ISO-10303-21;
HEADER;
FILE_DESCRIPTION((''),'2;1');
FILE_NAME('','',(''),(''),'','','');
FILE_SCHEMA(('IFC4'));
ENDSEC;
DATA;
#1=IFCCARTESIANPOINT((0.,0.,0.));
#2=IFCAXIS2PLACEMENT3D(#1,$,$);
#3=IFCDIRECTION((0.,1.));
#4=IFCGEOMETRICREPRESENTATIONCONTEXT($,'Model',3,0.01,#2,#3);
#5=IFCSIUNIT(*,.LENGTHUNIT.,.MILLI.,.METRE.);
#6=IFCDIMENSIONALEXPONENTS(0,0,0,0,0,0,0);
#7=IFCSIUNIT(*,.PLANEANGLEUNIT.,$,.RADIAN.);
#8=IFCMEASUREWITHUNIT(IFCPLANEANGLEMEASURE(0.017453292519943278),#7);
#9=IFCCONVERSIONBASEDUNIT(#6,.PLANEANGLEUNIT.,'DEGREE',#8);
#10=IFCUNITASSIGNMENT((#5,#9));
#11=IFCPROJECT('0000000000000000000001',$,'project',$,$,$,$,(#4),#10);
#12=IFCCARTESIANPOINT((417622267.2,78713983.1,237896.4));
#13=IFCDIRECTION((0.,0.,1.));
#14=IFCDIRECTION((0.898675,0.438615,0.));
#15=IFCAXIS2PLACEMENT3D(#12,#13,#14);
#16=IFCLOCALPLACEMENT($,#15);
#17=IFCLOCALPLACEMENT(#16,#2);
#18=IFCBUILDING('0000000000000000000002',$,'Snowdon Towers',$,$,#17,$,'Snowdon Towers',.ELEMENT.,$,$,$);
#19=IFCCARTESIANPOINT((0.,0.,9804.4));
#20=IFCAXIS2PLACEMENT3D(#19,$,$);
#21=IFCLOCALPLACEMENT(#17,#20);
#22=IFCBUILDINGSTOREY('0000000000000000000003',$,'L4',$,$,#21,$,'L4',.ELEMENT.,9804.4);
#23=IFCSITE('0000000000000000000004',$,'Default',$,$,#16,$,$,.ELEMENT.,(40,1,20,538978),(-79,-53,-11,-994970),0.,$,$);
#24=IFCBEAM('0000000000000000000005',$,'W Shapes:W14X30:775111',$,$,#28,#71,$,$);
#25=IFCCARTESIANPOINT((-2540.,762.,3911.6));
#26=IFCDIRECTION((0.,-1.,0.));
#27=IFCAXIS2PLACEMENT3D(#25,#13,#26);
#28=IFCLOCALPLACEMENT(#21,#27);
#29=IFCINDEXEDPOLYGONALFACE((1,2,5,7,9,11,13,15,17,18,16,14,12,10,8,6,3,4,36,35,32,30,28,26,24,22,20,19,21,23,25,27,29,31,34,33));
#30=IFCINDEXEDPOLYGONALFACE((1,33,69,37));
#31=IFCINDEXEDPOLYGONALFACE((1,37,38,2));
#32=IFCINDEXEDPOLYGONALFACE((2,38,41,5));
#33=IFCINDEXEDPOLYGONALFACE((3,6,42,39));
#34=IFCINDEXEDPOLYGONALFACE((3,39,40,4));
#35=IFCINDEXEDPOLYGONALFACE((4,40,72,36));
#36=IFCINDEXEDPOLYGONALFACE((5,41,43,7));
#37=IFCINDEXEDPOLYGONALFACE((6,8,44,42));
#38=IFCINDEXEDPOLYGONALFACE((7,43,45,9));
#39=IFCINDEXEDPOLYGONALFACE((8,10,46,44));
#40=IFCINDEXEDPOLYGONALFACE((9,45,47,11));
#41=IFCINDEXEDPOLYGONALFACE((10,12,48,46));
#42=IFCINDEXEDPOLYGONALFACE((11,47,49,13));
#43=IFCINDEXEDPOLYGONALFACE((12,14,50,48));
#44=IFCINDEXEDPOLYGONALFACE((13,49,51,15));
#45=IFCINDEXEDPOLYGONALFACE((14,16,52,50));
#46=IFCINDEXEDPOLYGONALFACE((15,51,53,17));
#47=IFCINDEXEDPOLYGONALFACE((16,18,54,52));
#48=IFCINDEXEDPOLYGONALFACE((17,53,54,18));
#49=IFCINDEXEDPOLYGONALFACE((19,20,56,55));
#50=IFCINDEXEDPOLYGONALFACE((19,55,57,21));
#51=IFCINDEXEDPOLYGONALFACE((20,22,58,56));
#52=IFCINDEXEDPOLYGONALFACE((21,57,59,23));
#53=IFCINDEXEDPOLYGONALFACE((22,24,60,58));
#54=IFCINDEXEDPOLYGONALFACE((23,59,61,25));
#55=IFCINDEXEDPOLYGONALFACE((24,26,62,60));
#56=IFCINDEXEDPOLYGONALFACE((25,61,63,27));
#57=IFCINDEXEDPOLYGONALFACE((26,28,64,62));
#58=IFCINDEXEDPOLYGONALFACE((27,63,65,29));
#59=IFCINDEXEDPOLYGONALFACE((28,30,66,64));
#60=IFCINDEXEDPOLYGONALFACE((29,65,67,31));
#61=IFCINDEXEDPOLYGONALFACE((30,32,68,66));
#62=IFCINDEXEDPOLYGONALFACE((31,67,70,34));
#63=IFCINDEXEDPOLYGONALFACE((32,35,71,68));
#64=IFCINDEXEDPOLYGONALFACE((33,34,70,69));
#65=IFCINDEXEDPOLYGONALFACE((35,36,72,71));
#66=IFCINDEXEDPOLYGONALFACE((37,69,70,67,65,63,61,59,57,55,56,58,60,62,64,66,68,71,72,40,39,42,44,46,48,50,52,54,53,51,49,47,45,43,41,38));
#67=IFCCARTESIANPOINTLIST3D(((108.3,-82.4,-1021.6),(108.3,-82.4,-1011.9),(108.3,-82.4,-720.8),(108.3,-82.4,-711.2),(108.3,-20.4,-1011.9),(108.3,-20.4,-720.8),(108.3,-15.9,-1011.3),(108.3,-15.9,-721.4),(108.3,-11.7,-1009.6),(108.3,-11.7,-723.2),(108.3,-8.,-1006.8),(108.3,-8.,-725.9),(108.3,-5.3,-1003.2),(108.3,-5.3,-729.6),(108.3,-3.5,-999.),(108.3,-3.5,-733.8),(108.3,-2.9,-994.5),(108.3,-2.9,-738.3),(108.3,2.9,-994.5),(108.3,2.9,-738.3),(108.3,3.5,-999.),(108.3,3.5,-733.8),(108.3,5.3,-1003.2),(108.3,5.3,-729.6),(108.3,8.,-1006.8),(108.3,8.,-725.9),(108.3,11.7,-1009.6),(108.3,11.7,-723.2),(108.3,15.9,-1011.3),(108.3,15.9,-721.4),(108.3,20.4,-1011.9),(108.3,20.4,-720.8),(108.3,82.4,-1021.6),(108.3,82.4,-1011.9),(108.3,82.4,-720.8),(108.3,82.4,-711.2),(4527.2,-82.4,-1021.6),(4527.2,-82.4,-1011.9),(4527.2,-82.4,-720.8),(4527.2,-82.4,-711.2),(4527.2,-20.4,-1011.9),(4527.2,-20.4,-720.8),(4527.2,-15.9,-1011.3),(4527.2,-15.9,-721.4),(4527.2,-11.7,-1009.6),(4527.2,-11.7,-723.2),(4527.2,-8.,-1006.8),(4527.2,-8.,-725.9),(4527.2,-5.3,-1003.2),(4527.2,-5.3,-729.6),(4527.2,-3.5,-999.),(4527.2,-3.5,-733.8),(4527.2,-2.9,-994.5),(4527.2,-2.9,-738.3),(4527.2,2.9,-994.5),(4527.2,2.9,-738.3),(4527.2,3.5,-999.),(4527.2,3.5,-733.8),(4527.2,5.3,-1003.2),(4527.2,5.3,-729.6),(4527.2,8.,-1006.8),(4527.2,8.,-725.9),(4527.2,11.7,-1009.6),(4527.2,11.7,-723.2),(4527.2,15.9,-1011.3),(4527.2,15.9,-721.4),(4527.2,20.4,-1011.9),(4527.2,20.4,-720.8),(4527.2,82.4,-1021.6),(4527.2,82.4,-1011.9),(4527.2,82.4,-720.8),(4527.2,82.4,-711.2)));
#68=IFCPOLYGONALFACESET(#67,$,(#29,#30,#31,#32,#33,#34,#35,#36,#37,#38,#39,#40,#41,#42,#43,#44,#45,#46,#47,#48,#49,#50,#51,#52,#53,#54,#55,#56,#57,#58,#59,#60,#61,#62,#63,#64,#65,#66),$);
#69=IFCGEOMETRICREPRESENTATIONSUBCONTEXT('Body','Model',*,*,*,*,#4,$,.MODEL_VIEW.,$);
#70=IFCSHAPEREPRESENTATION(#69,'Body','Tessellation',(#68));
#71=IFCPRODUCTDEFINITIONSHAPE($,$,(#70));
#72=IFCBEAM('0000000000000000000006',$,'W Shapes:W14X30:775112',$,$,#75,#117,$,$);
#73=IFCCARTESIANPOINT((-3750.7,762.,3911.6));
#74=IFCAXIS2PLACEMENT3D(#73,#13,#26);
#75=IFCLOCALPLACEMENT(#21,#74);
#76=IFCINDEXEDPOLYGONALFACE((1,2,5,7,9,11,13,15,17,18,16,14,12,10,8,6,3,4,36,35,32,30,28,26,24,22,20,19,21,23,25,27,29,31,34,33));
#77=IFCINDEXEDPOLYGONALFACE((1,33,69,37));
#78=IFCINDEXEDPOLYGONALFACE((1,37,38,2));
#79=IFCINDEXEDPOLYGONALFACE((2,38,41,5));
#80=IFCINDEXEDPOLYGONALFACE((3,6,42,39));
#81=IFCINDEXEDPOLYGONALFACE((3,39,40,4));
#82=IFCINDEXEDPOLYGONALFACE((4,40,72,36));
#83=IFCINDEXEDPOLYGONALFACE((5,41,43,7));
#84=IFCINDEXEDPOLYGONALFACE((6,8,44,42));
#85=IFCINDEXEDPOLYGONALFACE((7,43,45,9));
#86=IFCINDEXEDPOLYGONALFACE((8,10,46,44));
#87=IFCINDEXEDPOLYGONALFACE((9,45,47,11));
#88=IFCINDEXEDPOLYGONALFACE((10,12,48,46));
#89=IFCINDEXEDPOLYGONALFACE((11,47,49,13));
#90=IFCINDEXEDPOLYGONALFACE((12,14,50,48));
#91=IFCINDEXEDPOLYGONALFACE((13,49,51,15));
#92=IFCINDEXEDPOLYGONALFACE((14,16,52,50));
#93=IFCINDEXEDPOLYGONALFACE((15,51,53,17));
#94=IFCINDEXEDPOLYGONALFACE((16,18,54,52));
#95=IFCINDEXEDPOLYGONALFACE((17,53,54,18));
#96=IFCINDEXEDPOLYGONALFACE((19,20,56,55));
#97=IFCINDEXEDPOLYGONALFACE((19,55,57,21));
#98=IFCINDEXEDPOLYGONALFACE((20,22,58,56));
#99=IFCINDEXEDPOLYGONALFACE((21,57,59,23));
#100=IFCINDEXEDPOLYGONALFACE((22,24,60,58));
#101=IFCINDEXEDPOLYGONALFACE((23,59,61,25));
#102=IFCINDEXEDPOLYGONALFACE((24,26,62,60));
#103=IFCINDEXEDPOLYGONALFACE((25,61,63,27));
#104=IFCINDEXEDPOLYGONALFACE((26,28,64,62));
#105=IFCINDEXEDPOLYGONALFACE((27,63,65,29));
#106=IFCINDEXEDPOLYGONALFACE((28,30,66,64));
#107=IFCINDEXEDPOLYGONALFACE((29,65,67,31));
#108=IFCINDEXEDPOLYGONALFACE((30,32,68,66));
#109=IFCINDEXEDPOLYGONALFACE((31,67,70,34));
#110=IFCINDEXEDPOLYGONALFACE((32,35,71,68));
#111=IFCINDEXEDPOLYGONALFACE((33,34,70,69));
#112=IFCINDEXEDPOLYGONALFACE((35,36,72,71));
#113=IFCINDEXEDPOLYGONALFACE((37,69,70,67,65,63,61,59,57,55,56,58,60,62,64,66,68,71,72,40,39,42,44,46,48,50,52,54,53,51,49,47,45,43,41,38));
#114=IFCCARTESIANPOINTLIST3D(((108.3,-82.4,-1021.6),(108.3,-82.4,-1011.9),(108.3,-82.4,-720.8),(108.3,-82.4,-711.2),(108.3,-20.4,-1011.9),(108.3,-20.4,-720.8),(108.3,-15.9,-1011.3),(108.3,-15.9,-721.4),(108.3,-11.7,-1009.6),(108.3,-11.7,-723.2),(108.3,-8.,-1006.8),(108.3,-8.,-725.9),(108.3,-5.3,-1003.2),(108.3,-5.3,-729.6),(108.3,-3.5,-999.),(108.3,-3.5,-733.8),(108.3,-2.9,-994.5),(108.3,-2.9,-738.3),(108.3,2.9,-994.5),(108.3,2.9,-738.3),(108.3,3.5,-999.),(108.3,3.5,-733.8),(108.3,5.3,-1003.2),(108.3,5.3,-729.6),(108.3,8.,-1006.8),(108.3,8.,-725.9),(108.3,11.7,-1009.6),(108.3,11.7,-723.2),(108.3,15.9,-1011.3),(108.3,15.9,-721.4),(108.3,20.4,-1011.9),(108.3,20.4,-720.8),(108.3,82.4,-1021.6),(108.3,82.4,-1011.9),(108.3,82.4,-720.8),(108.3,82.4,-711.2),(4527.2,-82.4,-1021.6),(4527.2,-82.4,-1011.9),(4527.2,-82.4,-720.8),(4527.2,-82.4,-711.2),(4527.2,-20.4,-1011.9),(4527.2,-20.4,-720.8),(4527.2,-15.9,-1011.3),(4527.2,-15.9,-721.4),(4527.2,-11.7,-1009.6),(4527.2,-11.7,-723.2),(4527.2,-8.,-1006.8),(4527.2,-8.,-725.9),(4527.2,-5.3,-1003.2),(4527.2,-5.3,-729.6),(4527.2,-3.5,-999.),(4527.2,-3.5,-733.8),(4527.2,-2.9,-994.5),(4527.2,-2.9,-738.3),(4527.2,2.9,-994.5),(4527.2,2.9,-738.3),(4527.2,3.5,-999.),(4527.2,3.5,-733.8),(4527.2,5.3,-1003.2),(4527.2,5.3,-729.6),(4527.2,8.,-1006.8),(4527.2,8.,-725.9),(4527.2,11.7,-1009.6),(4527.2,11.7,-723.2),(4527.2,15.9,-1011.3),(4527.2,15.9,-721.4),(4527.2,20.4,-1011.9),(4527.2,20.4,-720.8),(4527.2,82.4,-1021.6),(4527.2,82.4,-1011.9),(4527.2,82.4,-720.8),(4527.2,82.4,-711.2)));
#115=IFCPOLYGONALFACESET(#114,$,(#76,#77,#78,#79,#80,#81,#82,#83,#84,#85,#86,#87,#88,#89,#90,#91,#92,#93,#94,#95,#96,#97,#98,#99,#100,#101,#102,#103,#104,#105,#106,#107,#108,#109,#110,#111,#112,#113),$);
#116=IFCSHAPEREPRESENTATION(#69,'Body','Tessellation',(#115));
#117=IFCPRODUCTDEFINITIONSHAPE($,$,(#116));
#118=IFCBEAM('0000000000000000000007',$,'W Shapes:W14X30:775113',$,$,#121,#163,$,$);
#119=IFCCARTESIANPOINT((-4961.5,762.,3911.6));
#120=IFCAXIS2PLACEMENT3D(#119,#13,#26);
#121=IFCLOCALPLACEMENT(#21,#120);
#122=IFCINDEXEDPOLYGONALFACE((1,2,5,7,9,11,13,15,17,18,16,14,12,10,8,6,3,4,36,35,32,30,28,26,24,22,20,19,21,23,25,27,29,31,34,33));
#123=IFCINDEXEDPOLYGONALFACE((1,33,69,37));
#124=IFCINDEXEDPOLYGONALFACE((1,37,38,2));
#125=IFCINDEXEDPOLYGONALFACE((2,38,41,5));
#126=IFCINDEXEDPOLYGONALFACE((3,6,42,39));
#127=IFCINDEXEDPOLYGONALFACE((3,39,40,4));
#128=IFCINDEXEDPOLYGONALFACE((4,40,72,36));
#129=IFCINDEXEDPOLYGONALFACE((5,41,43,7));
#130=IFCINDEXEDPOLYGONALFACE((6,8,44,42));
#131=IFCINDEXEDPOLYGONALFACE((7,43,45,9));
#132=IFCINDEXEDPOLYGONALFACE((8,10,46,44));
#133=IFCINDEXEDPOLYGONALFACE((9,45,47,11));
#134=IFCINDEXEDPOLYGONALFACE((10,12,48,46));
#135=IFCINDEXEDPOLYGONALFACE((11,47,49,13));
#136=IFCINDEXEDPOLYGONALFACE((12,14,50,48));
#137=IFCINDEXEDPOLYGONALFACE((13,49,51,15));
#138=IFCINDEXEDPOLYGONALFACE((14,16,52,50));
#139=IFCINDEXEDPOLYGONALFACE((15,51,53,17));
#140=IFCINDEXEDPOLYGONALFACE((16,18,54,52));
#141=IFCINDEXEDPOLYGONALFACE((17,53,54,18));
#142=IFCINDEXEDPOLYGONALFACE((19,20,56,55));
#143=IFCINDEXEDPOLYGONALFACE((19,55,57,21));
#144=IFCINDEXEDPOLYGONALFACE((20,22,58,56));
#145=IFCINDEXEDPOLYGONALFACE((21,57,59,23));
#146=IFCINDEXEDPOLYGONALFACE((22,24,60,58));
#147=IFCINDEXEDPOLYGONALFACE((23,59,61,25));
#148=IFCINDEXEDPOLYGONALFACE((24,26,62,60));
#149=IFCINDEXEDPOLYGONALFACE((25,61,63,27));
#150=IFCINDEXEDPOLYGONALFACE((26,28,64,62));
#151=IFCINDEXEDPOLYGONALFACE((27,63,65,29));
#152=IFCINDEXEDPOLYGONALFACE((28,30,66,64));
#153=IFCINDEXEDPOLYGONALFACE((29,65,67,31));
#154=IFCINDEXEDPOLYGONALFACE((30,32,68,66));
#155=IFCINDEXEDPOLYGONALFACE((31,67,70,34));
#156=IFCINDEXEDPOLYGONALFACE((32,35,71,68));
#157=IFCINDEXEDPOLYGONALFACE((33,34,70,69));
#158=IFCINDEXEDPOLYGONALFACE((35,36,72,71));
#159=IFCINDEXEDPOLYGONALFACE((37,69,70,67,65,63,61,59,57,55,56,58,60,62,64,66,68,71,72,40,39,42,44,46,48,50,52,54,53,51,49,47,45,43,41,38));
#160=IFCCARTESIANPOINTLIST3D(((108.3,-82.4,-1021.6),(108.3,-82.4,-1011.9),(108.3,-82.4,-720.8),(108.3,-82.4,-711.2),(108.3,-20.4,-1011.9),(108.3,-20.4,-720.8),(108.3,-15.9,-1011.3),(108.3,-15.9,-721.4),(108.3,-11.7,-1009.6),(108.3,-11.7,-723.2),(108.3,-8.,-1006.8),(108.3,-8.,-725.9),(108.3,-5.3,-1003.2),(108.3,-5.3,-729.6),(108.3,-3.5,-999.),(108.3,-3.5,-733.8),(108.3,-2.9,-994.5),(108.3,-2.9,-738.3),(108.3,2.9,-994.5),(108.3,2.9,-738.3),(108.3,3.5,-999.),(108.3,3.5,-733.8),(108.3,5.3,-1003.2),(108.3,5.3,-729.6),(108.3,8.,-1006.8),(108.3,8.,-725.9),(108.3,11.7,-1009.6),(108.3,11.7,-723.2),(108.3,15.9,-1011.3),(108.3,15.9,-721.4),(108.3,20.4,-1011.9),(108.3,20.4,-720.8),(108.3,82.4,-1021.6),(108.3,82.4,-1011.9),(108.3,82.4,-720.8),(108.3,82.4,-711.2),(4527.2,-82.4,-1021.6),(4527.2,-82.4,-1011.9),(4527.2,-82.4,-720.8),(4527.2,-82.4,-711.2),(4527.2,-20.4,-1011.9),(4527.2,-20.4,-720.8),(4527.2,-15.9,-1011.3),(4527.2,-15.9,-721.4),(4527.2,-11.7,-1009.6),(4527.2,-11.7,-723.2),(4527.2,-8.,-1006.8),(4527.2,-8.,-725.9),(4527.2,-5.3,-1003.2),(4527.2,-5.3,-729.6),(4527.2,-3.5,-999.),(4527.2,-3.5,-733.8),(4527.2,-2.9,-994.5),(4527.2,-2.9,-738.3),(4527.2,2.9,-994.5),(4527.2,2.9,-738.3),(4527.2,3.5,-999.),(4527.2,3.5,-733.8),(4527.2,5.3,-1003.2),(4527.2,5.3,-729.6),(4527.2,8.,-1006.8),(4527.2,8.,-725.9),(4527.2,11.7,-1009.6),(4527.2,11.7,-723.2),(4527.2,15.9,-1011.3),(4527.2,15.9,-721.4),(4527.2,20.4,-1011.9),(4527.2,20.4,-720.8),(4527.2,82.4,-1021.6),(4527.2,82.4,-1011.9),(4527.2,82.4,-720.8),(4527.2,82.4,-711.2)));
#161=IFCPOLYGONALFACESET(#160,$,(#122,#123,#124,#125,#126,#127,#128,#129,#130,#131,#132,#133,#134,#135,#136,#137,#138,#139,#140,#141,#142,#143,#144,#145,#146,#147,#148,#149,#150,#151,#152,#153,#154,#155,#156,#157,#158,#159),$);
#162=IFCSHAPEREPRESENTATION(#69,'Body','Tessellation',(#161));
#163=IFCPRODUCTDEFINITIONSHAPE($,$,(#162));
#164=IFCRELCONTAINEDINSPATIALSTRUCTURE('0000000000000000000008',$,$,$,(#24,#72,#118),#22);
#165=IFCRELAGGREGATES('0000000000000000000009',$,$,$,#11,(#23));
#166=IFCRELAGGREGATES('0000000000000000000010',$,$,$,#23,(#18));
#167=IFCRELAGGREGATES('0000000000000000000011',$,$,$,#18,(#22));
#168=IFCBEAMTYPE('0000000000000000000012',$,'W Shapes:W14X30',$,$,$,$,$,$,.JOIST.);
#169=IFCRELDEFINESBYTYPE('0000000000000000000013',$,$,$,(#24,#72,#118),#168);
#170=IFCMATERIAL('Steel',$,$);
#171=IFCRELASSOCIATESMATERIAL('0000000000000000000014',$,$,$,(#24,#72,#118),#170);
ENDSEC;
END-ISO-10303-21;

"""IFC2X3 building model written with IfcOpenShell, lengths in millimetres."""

from ifc_helpers import new_model, entity, si_unit, converted_unit, direction, frame, frame_2d, origin, place, context, subcontext, project, spatial, i_section, extrude, material, type_object, element, save


model = new_model("IFC2X3")

# Units and contexts
model_context = context("Model", 3, precision=0.01, world=origin(), true_north=direction((0.0, 1.0)))
body_context = subcontext(model_context, "Body", "Model", "MODEL_VIEW")
ifc_project = project(units=[si_unit("LENGTHUNIT", "METRE", prefix="MILLI"), converted_unit("PLANEANGLEUNIT", "DEGREE", entity("IfcPlaneAngleMeasure", 0.017453292519943278), si_unit("PLANEANGLEUNIT", "RADIAN"), dimensions=[0, 0, 0, 0, 0, 0, 0])], contexts=[model_context])

# Site, building, storey
site_placement = place(None, frame((417622267.2, 78713983.1, 237896.4), z_axis=(0.0, 0.0, 1.0), x_axis=(0.898675, 0.438615, 0.0)))
site = spatial("IfcSite", under=ifc_project, at=site_placement, Name="Default", CompositionType="ELEMENT", RefLatitude=(40, 1, 20, 538978), RefLongitude=(-79, -53, -11, -994970), RefElevation=0.0)
building_placement = place(site_placement, origin())
building = spatial("IfcBuilding", under=site, at=building_placement, Name="Snowdon Towers", LongName="Snowdon Towers", CompositionType="ELEMENT")
storey_placement = place(building_placement, frame((0.0, 0.0, 9804.4)))
storey = spatial("IfcBuildingStorey", under=building, at=storey_placement, Name="L4", LongName="L4", CompositionType="ELEMENT", Elevation=9804.4)

# Shared definitions
ifc_material_1 = material(Name="Steel")

# Beams
beam_type_1 = type_object("IfcBeamType", Name="W Shapes:W14X30", PredefinedType="JOIST")
beam_1_placement = place(storey_placement, frame((-2540.0, 762.0, 3911.6), z_axis=(0.0, 0.0, 1.0), x_axis=(0.0, -1.0, 0.0)))
element("IfcBeam", 1, at=beam_1_placement, inside=storey, type_object=beam_type_1, material=ifc_material_1, Name="W Shapes:W14X30:775111", context=body_context, shape_type="SweptSolid", body=[
    extrude(i_section(OverallWidth=164.8, OverallDepth=310.4, WebThickness=5.9, FlangeThickness=9.6, FilletRadius=17.5, at=frame_2d((0.0, 0.0), x_axis=(0.0, 1.0))), frame((108.3, 0.0, -866.4), z_axis=(1.0, 0.0, 0.0), x_axis=(0.0, 0.0, -1.0)), (0.0, 0.0, 1.0), 4418.8),
])
beam_2_placement = place(storey_placement, frame((-3750.7, 762.0, 3911.6), z_axis=(0.0, 0.0, 1.0), x_axis=(0.0, -1.0, 0.0)))
element("IfcBeam", 2, at=beam_2_placement, inside=storey, type_object=beam_type_1, material=ifc_material_1, Name="W Shapes:W14X30:775112", context=body_context, shape_type="SweptSolid", body=[
    extrude(i_section(OverallWidth=164.8, OverallDepth=310.4, WebThickness=5.9, FlangeThickness=9.6, FilletRadius=17.5, at=frame_2d((0.0, 0.0), x_axis=(0.0, 1.0))), frame((108.3, 0.0, -866.4), z_axis=(1.0, 0.0, 0.0), x_axis=(0.0, 0.0, -1.0)), (0.0, 0.0, 1.0), 4418.8),
])
beam_3_placement = place(storey_placement, frame((-4961.5, 762.0, 3911.6), z_axis=(0.0, 0.0, 1.0), x_axis=(0.0, -1.0, 0.0)))
element("IfcBeam", 3, at=beam_3_placement, inside=storey, type_object=beam_type_1, material=ifc_material_1, Name="W Shapes:W14X30:775113", context=body_context, shape_type="SweptSolid", body=[
    extrude(i_section(OverallWidth=164.8, OverallDepth=310.4, WebThickness=5.9, FlangeThickness=9.6, FilletRadius=17.5, at=frame_2d((0.0, 0.0), x_axis=(0.0, 1.0))), frame((108.3, 0.0, -866.4), z_axis=(1.0, 0.0, 0.0), x_axis=(0.0, 0.0, -1.0)), (0.0, 0.0, 1.0), 4418.8),
])

save(model, "model.ifc")
